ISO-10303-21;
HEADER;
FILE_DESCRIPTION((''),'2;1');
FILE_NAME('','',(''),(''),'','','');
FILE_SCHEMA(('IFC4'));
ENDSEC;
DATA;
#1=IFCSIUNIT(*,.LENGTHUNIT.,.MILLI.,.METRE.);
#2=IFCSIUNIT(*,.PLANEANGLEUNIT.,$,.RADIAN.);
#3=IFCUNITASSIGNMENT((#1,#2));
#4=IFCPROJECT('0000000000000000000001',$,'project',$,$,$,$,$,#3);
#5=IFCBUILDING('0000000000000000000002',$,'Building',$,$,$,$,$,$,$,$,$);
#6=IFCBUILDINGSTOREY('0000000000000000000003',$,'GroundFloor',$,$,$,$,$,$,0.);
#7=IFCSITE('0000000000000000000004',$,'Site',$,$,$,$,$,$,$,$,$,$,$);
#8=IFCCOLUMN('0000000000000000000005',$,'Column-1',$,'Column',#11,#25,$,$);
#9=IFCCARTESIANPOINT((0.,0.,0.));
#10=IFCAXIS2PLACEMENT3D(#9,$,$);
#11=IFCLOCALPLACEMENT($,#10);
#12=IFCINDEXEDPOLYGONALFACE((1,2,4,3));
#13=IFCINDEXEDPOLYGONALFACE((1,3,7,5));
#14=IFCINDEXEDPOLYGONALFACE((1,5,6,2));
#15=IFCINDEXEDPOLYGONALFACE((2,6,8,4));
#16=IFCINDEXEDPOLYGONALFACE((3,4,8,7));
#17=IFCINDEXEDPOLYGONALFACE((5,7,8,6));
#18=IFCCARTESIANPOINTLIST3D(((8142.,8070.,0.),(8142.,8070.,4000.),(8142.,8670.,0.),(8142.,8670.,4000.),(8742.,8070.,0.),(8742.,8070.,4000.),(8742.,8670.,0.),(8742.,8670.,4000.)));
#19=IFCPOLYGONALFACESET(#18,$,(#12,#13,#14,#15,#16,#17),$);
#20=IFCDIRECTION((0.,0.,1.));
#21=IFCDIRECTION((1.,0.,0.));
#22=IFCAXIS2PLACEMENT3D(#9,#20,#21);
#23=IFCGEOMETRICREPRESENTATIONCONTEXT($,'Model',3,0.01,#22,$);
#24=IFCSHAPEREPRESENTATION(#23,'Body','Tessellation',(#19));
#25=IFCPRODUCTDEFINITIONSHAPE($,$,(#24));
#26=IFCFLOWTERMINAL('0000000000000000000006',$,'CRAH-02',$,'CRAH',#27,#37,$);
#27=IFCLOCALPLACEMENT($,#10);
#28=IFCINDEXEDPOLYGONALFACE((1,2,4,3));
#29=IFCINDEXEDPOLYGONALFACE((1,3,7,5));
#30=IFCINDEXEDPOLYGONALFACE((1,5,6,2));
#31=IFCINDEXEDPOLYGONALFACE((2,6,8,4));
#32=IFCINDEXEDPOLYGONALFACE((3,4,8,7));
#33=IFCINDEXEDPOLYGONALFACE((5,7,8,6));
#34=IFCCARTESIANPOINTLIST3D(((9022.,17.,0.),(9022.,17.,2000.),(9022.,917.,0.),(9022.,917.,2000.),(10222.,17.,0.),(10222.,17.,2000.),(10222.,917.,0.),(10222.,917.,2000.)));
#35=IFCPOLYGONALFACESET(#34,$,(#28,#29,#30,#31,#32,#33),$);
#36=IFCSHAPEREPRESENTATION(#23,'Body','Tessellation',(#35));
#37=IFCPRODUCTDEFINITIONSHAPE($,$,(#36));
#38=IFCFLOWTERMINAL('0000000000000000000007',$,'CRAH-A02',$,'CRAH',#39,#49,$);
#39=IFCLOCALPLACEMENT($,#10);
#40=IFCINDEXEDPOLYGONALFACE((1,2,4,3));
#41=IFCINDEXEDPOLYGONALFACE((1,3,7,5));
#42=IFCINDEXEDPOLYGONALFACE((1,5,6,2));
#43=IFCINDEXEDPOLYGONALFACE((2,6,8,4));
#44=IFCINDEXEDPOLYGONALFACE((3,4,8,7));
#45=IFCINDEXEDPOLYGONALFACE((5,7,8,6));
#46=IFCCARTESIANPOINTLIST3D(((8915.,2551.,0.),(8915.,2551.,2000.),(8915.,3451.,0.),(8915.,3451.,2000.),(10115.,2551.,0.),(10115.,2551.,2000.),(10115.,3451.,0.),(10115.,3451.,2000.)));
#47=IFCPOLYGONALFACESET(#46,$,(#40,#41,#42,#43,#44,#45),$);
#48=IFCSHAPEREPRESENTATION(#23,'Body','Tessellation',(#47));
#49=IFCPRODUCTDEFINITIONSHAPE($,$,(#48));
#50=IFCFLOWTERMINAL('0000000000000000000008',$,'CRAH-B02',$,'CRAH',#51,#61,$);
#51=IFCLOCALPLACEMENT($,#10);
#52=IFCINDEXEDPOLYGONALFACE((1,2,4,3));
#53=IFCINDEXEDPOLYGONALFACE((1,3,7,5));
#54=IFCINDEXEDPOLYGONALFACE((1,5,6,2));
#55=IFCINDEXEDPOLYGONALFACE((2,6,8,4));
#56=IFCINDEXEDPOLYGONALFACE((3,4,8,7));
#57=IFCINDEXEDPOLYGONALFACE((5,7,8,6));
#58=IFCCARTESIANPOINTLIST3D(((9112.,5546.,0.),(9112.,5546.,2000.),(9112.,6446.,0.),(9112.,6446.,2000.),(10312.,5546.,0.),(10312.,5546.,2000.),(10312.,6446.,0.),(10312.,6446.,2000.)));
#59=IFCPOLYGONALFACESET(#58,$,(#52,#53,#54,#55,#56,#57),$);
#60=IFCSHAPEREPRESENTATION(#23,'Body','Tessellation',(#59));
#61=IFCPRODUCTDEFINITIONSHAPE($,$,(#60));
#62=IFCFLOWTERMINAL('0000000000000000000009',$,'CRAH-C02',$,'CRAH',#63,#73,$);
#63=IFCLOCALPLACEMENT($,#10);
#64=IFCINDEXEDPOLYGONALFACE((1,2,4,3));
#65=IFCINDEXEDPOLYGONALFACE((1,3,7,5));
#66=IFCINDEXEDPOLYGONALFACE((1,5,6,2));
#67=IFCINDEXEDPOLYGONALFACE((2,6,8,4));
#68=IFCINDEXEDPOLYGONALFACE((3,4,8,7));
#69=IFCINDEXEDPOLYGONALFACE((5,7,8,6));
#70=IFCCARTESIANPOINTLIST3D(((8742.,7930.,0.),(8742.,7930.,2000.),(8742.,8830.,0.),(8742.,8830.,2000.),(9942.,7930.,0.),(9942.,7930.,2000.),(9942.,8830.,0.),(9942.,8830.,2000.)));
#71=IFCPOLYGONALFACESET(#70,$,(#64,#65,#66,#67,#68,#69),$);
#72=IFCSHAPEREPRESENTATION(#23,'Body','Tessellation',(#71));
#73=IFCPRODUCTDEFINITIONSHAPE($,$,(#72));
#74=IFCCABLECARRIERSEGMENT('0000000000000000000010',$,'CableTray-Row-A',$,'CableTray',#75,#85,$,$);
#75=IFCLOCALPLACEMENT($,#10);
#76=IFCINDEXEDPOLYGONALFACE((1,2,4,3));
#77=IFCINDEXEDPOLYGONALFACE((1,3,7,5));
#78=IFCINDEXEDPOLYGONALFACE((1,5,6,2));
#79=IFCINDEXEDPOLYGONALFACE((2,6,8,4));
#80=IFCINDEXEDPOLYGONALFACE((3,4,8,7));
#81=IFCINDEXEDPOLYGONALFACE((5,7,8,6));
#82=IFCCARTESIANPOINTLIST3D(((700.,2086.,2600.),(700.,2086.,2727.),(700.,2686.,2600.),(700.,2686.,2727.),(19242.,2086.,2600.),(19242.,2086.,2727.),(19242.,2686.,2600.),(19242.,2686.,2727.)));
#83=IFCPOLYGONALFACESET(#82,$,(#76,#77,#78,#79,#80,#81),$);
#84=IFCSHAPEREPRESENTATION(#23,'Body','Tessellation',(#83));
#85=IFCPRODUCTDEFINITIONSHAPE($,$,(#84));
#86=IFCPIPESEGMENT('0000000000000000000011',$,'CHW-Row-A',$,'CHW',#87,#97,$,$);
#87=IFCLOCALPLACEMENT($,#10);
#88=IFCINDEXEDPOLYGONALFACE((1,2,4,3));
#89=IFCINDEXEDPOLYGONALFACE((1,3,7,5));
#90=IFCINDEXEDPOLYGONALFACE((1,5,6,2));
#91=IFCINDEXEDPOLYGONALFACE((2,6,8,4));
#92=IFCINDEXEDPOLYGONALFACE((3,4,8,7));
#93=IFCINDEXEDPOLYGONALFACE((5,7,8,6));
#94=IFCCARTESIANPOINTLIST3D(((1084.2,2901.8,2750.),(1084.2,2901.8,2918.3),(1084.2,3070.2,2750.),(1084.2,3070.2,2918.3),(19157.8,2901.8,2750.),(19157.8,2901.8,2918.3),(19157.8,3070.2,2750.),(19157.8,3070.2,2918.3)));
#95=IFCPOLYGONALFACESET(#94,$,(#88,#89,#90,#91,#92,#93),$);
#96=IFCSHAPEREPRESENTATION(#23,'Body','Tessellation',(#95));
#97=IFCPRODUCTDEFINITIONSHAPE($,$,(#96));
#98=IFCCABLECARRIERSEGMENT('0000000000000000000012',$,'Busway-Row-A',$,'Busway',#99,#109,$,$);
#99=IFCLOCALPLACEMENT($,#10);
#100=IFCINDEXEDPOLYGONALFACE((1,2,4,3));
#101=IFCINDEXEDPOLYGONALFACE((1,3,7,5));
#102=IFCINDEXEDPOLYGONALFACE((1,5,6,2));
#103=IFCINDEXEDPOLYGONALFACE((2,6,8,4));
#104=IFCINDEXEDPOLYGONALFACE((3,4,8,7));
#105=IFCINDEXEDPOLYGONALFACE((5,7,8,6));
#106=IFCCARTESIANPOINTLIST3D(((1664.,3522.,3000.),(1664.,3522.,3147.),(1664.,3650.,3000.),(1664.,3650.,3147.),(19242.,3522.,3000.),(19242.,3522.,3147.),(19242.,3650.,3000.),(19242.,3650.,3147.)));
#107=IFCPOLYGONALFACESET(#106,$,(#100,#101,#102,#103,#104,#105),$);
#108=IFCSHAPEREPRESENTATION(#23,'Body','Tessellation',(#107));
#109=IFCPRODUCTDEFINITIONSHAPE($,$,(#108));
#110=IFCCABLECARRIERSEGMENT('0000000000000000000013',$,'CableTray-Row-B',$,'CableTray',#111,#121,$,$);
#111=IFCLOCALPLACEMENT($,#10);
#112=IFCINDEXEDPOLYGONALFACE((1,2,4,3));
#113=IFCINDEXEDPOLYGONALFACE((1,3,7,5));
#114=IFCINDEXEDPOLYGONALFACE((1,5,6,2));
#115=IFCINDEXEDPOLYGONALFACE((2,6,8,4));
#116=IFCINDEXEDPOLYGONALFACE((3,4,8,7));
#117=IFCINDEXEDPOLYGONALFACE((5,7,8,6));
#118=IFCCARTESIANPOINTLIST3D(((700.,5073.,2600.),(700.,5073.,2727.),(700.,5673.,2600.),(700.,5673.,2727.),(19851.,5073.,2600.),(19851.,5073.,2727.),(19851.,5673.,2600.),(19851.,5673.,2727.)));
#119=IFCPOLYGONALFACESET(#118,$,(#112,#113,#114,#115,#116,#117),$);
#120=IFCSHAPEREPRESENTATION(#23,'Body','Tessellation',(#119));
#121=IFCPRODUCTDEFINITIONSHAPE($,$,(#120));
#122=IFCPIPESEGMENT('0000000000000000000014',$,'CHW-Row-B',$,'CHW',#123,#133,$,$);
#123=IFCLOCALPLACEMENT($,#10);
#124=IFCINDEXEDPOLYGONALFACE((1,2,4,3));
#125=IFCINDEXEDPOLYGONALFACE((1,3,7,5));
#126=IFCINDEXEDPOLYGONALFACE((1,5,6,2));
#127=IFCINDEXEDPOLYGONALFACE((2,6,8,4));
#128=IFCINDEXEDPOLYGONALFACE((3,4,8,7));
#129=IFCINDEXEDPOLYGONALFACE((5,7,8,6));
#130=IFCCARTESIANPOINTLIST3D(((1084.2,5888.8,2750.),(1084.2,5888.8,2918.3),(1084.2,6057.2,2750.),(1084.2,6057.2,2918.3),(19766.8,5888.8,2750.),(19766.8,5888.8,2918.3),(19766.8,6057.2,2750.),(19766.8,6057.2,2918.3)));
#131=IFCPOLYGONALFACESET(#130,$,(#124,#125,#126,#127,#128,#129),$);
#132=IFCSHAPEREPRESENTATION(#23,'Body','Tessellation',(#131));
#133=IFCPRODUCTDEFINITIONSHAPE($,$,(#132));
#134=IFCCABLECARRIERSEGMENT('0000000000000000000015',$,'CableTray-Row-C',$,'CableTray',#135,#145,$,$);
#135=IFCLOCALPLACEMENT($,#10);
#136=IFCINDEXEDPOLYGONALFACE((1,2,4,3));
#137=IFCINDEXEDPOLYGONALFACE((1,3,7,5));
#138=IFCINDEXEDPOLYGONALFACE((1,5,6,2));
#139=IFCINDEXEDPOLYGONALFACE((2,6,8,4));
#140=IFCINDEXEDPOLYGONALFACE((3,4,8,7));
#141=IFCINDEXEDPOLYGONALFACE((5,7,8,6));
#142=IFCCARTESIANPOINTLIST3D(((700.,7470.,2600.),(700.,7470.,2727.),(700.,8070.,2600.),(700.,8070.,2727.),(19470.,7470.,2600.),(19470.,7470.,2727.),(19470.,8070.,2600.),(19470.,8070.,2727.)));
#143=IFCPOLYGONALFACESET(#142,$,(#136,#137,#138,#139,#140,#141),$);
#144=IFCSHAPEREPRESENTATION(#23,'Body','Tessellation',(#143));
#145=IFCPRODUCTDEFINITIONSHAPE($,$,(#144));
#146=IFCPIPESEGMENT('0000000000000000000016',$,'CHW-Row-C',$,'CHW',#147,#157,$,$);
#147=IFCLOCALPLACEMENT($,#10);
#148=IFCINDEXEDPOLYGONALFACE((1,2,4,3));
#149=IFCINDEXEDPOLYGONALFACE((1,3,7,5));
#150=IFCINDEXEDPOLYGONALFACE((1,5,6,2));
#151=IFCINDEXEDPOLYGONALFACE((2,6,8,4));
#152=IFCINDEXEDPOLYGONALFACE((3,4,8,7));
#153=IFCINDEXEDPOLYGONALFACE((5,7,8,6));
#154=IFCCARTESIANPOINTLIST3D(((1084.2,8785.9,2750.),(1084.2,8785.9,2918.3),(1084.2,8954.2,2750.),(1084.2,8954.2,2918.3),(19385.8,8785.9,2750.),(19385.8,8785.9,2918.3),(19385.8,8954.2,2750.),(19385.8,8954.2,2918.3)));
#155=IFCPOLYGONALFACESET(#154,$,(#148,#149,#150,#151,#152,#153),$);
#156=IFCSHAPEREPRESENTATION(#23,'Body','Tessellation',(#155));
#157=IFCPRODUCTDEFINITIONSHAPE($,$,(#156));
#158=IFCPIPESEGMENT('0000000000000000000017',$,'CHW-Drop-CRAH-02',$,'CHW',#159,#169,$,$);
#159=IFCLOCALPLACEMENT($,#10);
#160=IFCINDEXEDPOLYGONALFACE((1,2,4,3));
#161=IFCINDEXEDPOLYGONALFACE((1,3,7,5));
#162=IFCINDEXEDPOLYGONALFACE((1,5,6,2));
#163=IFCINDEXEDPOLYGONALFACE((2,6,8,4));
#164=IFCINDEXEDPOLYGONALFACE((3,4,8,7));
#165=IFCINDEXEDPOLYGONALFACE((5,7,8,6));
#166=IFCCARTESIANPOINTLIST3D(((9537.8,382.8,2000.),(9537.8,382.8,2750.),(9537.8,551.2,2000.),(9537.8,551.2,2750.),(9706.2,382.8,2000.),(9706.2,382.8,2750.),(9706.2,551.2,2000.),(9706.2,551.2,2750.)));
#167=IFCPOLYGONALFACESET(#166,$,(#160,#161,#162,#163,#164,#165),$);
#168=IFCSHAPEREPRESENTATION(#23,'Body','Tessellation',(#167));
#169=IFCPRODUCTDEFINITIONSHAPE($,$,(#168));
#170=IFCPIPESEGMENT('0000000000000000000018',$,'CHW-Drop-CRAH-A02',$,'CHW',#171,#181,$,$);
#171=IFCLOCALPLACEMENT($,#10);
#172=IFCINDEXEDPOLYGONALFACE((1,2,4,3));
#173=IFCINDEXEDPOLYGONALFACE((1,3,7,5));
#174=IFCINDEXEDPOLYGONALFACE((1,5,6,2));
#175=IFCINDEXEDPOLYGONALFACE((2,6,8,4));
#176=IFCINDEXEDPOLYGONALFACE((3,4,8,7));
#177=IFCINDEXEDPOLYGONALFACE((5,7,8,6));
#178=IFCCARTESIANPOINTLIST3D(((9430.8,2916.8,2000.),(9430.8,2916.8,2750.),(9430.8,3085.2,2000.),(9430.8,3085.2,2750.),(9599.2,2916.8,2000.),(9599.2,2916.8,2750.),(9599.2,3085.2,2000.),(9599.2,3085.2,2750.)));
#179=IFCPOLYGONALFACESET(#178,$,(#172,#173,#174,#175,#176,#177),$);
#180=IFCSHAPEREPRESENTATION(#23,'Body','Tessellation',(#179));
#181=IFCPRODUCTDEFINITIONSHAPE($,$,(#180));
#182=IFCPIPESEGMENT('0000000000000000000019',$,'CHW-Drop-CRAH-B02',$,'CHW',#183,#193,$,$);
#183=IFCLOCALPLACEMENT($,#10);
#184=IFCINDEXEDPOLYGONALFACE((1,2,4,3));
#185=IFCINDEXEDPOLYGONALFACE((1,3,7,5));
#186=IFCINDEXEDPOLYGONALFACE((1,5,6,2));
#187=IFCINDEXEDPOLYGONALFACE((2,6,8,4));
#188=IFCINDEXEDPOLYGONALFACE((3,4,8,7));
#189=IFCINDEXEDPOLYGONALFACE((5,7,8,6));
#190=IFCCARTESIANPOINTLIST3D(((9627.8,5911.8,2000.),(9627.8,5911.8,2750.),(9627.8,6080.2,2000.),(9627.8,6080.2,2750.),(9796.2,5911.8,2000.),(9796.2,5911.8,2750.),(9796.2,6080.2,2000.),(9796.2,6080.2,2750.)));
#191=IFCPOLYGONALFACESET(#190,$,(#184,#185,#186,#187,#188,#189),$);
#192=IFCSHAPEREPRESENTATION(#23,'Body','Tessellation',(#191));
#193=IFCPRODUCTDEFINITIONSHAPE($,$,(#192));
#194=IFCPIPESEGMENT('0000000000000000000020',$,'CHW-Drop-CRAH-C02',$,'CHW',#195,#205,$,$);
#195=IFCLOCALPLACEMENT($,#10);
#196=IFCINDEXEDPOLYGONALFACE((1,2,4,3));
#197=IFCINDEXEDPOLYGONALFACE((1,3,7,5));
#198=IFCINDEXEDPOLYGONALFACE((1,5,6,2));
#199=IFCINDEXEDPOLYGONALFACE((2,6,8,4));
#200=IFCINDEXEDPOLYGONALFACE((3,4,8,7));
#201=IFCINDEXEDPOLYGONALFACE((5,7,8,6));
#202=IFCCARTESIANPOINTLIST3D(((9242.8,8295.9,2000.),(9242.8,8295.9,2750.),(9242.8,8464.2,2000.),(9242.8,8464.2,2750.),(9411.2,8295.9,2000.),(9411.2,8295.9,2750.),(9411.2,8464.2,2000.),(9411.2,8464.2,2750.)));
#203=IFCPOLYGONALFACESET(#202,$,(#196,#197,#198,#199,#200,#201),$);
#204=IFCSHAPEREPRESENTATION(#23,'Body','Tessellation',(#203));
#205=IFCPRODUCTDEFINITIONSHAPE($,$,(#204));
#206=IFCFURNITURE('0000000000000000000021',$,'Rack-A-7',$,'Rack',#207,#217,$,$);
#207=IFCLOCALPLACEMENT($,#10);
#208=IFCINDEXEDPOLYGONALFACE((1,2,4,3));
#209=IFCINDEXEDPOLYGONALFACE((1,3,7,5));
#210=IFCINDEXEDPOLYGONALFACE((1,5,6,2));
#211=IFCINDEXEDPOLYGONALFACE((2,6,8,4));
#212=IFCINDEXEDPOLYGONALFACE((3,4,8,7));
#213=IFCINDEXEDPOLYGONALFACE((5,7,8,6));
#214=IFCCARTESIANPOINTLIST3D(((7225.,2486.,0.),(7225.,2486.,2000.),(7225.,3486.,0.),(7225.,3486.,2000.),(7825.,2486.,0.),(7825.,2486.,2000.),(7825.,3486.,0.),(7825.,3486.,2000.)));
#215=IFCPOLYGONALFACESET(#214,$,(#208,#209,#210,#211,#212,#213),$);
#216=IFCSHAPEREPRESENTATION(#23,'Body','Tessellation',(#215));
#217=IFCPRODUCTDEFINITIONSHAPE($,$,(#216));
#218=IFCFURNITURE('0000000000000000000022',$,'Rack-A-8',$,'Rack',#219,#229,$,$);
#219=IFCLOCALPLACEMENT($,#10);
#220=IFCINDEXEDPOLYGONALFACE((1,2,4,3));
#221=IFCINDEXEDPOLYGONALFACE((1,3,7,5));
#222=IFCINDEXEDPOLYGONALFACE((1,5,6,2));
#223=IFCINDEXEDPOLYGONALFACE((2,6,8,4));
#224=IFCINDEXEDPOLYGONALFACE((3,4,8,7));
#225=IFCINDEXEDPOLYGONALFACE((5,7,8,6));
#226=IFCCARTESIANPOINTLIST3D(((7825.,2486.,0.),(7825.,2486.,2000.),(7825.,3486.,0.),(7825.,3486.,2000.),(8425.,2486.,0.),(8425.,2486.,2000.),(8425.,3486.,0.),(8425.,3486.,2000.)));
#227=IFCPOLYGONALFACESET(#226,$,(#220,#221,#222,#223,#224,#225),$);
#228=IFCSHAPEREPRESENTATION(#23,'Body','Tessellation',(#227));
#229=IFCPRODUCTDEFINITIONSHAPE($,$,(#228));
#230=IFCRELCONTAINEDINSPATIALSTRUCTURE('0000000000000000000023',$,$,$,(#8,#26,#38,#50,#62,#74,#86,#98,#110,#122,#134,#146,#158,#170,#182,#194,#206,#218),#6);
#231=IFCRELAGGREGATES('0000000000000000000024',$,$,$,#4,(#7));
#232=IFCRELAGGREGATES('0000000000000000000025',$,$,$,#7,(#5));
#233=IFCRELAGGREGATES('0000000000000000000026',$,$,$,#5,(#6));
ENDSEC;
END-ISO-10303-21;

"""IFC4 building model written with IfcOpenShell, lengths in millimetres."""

from ifc_helpers import new_model, si_unit, frame, origin, origin_with_axes, origin_2d, place, context, project, spatial, rectangle, extrude, element, save


model = new_model("IFC4")

# Units and contexts
model_context = context("Model", 3, precision=0.01, world=origin_with_axes())
ifc_project = project(units=[si_unit("LENGTHUNIT", "METRE", prefix="MILLI"), si_unit("PLANEANGLEUNIT", "RADIAN")])

# Site, building, storey
site = spatial("IfcSite", under=ifc_project, Name="Site")
building = spatial("IfcBuilding", under=site, Name="Building")
storey = spatial("IfcBuildingStorey", under=building, Name="GroundFloor", Elevation=0.0)

# Column
column_placement = place(None, frame((8442.0, 8370.0, 0.0), z_axis=(0.0, 0.0, 1.0), x_axis=(1.0, 0.0, 0.0)))
element("IfcColumn", 1, at=column_placement, inside=storey, Name="Column-1", ObjectType="Column", context=model_context, shape_type="SweptSolid", body=[
    extrude(rectangle(XDim=600.0, YDim=600.0, at=origin_2d()), origin(), (0.0, 0.0, 1.0), 4000.0),
])

# Flow terminals
for number, where, z_axis, x_axis, name in (
    (2, (9622.0, 467.0, 0.0), (0.0, 0.0, 1.0), (1.0, 0.0, 0.0), "CRAH-02"),
    (3, (9515.0, 3001.0, 0.0), (0.0, 0.0, 1.0), (1.0, 0.0, 0.0), "CRAH-A02"),
    (4, (9712.0, 5996.0, 0.0), (0.0, 0.0, 1.0), (1.0, 0.0, 0.0), "CRAH-B02"),
    (5, (9342.0, 8380.0, 0.0), (0.0, 0.0, 1.0), (1.0, 0.0, 0.0), "CRAH-C02"),
):
    element("IfcFlowTerminal", number, at=place(None, frame(where, z_axis=z_axis, x_axis=x_axis)), inside=storey, Name=name, ObjectType="CRAH", context=model_context, shape_type="SweptSolid", body=[
        extrude(rectangle(XDim=1200.0, YDim=900.0, at=origin_2d()), origin(), (0.0, 0.0, 1.0), 2000.0),
    ])

# Cable carrier segment
cable_carrier_segment_1_placement = place(None, frame((9971.0, 2386.0, 2600.0), z_axis=(0.0, 0.0, 1.0), x_axis=(1.0, 0.0, 0.0)))
element("IfcCableCarrierSegment", 6, at=cable_carrier_segment_1_placement, inside=storey, Name="CableTray-Row-A", ObjectType="CableTray", context=model_context, shape_type="SweptSolid", body=[
    extrude(rectangle(XDim=18542.0, YDim=600.0, at=origin_2d()), origin(), (0.0, 0.0, 1.0), 127.0),
])

# Pipe segment
pipe_segment_1_placement = place(None, frame((10121.0, 2986.0, 2750.0), z_axis=(0.0, 0.0, 1.0), x_axis=(1.0, 0.0, 0.0)))
element("IfcPipeSegment", 7, at=pipe_segment_1_placement, inside=storey, Name="CHW-Row-A", ObjectType="CHW", context=model_context, shape_type="SweptSolid", body=[
    extrude(rectangle(XDim=18073.7, YDim=168.3, at=origin_2d()), origin(), (0.0, 0.0, 1.0), 168.3),
])

# Cable carrier segments
cable_carrier_segment_2_placement = place(None, frame((10453.0, 3586.0, 3000.0), z_axis=(0.0, 0.0, 1.0), x_axis=(1.0, 0.0, 0.0)))
element("IfcCableCarrierSegment", 8, at=cable_carrier_segment_2_placement, inside=storey, Name="Busway-Row-A", ObjectType="Busway", context=model_context, shape_type="SweptSolid", body=[
    extrude(rectangle(XDim=17578.0, YDim=128.0, at=origin_2d()), origin(), (0.0, 0.0, 1.0), 147.0),
])
cable_carrier_segment_3_placement = place(None, frame((10275.5, 5373.0, 2600.0), z_axis=(0.0, 0.0, 1.0), x_axis=(1.0, 0.0, 0.0)))
element("IfcCableCarrierSegment", 9, at=cable_carrier_segment_3_placement, inside=storey, Name="CableTray-Row-B", ObjectType="CableTray", context=model_context, shape_type="SweptSolid", body=[
    extrude(rectangle(XDim=19151.0, YDim=600.0, at=origin_2d()), origin(), (0.0, 0.0, 1.0), 127.0),
])

# Pipe segment
pipe_segment_2_placement = place(None, frame((10425.5, 5973.0, 2750.0), z_axis=(0.0, 0.0, 1.0), x_axis=(1.0, 0.0, 0.0)))
element("IfcPipeSegment", 10, at=pipe_segment_2_placement, inside=storey, Name="CHW-Row-B", ObjectType="CHW", context=model_context, shape_type="SweptSolid", body=[
    extrude(rectangle(XDim=18682.7, YDim=168.3, at=origin_2d()), origin(), (0.0, 0.0, 1.0), 168.3),
])

# Cable carrier segment
cable_carrier_segment_4_placement = place(None, frame((10085.0, 7770.0, 2600.0), z_axis=(0.0, 0.0, 1.0), x_axis=(1.0, 0.0, 0.0)))
element("IfcCableCarrierSegment", 11, at=cable_carrier_segment_4_placement, inside=storey, Name="CableTray-Row-C", ObjectType="CableTray", context=model_context, shape_type="SweptSolid", body=[
    extrude(rectangle(XDim=18770.0, YDim=600.0, at=origin_2d()), origin(), (0.0, 0.0, 1.0), 127.0),
])

# Pipe segments
pipe_segment_3_placement = place(None, frame((10235.0, 8870.0, 2750.0), z_axis=(0.0, 0.0, 1.0), x_axis=(1.0, 0.0, 0.0)))
element("IfcPipeSegment", 12, at=pipe_segment_3_placement, inside=storey, Name="CHW-Row-C", ObjectType="CHW", context=model_context, shape_type="SweptSolid", body=[
    extrude(rectangle(XDim=18301.7, YDim=168.3, at=origin_2d()), origin(), (0.0, 0.0, 1.0), 168.3),
])
for number, where, z_axis, x_axis, name in (
    (13, (9622.0, 467.0, 2000.0), (0.0, 0.0, 1.0), (1.0, 0.0, 0.0), "CHW-Drop-CRAH-02"),
    (14, (9515.0, 3001.0, 2000.0), (0.0, 0.0, 1.0), (1.0, 0.0, 0.0), "CHW-Drop-CRAH-A02"),
    (15, (9712.0, 5996.0, 2000.0), (0.0, 0.0, 1.0), (1.0, 0.0, 0.0), "CHW-Drop-CRAH-B02"),
    (16, (9327.0, 8380.0, 2000.0), (0.0, 0.0, 1.0), (1.0, 0.0, 0.0), "CHW-Drop-CRAH-C02"),
):
    element("IfcPipeSegment", number, at=place(None, frame(where, z_axis=z_axis, x_axis=x_axis)), inside=storey, Name=name, ObjectType="CHW", context=model_context, shape_type="SweptSolid", body=[
        extrude(rectangle(XDim=168.3, YDim=168.3, at=origin_2d()), origin(), (0.0, 0.0, 1.0), 750.0),
    ])

# Furniture
for number, where, z_axis, x_axis, name in (
    (17, (7525.0, 2986.0, 0.0), (0.0, 0.0, 1.0), (1.0, 0.0, 0.0), "Rack-A-7"),
    (18, (8125.0, 2986.0, 0.0), (0.0, 0.0, 1.0), (1.0, 0.0, 0.0), "Rack-A-8"),
):
    element("IfcFurniture", number, at=place(None, frame(where, z_axis=z_axis, x_axis=x_axis)), inside=storey, Name=name, ObjectType="Rack", context=model_context, shape_type="SweptSolid", body=[
        extrude(rectangle(XDim=600.0, YDim=1000.0, at=origin_2d()), origin(), (0.0, 0.0, 1.0), 2000.0),
    ])

save(model, "model.ifc")
